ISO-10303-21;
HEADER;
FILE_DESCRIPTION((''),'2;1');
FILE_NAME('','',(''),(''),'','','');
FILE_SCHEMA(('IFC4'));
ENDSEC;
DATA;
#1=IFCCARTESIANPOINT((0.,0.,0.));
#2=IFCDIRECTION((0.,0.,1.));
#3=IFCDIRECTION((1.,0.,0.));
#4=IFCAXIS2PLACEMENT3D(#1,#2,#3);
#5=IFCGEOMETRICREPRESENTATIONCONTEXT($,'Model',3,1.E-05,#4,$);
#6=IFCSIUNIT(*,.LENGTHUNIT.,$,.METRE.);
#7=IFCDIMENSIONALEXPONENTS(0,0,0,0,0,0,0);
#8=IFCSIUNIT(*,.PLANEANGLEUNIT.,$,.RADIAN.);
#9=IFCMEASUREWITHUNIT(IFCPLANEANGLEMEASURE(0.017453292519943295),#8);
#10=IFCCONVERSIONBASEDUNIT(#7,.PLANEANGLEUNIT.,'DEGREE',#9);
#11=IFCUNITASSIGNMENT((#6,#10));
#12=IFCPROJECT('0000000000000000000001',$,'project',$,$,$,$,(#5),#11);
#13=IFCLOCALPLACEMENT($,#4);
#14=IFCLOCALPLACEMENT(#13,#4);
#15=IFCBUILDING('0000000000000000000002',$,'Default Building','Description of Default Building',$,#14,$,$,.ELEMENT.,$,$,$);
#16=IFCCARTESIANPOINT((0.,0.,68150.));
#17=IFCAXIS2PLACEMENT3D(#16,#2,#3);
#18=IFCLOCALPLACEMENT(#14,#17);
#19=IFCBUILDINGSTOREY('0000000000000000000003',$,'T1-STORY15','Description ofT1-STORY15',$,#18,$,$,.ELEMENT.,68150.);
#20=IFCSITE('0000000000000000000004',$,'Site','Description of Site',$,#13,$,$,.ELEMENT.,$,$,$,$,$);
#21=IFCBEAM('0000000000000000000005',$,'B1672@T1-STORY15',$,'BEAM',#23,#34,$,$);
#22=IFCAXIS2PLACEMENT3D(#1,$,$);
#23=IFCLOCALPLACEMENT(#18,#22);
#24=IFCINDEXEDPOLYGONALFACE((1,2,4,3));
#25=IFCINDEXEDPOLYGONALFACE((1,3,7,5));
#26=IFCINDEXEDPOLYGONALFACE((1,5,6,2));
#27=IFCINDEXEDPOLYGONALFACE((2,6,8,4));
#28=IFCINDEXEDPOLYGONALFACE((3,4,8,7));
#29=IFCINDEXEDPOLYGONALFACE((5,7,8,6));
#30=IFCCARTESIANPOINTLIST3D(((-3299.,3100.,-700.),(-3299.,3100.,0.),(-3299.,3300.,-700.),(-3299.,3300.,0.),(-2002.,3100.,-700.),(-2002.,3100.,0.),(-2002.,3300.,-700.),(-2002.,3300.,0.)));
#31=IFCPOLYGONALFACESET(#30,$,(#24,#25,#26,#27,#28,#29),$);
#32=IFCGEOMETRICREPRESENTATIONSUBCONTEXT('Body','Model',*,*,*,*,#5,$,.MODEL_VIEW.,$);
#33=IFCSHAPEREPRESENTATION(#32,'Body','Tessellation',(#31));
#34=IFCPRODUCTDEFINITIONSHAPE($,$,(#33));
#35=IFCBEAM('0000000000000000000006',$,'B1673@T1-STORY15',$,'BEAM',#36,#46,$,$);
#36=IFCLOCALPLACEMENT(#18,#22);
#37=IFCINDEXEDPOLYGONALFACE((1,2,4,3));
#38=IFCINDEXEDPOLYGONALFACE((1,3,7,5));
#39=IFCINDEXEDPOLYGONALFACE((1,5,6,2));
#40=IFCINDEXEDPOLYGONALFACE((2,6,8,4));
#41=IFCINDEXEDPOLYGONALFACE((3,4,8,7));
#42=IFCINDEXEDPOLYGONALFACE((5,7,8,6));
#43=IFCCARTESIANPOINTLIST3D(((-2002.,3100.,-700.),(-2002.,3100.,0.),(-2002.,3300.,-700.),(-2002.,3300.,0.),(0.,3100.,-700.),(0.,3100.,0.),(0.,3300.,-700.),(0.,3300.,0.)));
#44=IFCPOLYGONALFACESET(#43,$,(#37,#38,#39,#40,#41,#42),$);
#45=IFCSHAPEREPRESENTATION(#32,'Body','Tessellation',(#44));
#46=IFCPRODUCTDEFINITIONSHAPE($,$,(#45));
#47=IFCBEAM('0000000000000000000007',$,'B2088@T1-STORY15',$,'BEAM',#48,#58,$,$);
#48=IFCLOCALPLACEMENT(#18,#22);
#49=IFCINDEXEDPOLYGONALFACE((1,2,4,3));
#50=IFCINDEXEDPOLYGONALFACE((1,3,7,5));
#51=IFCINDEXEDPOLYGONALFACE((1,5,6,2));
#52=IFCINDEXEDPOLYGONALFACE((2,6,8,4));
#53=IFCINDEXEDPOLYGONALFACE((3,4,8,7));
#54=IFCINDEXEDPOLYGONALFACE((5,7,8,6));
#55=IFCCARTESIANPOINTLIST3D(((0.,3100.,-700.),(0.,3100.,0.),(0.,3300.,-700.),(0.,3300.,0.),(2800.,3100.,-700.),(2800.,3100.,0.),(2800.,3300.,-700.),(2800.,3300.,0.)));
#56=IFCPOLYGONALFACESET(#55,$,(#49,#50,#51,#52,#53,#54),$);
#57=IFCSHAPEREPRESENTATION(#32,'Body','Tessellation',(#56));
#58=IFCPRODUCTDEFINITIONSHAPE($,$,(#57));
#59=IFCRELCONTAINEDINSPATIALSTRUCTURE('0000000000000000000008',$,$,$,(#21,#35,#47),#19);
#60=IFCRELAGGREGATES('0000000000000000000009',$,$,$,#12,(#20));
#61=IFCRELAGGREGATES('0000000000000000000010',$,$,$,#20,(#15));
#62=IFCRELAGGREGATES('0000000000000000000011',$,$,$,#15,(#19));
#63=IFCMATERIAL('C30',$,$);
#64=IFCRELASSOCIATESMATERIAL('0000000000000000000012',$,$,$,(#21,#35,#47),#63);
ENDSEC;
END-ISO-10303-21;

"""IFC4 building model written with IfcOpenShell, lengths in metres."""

from ifc_helpers import new_model, entity, si_unit, converted_unit, frame, origin_with_axes, place, context, subcontext, project, spatial, rectangle, extrude, material, element, save


model = new_model("IFC4")

# Units and contexts
model_context = context("Model", 3, precision=1e-05, world=origin_with_axes())
body_context = subcontext(model_context, "Body", "Model", "MODEL_VIEW")
ifc_project = project(units=[si_unit("LENGTHUNIT", "METRE"), converted_unit("PLANEANGLEUNIT", "DEGREE", entity("IfcPlaneAngleMeasure", 0.017453292519943295), si_unit("PLANEANGLEUNIT", "RADIAN"), dimensions=[0, 0, 0, 0, 0, 0, 0])], contexts=[model_context])

# Site, building, storey
site_placement = place(None, origin_with_axes())
site = spatial("IfcSite", under=ifc_project, at=site_placement, Name="Site", Description="Description of Site", CompositionType="ELEMENT")
building_placement = place(site_placement, origin_with_axes())
building = spatial("IfcBuilding", under=site, at=building_placement, Name="Default Building", Description="Description of Default Building", CompositionType="ELEMENT")
storey_placement = place(building_placement, frame((0.0, 0.0, 68150.0), z_axis=(0.0, 0.0, 1.0), x_axis=(1.0, 0.0, 0.0)))
storey = spatial("IfcBuildingStorey", under=building, at=storey_placement, Name="T1-STORY15", Description="Description ofT1-STORY15", CompositionType="ELEMENT", Elevation=68150.0)

# Beams
ifc_material_1 = material(Name="C30")
beam_1_placement = place(storey_placement, frame((-3299.0, 3200.0, -350.0), z_axis=(1.0, 0.0, 0.0), x_axis=(0.0, 1.0, 0.0)))
element("IfcBeam", 1, at=beam_1_placement, inside=storey, material=ifc_material_1, Name="B1672@T1-STORY15", ObjectType="BEAM", context=body_context, shape_type="SweptSolid", body=[
    extrude(rectangle(XDim=200.0, YDim=700.0), origin_with_axes(), (0.0, 0.0, 1.0), 1297.0),
])
beam_2_placement = place(storey_placement, frame((-2002.0, 3200.0, -350.0), z_axis=(1.0, 0.0, 0.0), x_axis=(0.0, 1.0, 0.0)))
element("IfcBeam", 2, at=beam_2_placement, inside=storey, material=ifc_material_1, Name="B1673@T1-STORY15", ObjectType="BEAM", context=body_context, shape_type="SweptSolid", body=[
    extrude(rectangle(XDim=200.0, YDim=700.0), origin_with_axes(), (0.0, 0.0, 1.0), 2002.0),
])
beam_3_placement = place(storey_placement, frame((0.0, 3200.0, -350.0), z_axis=(1.0, 0.0, 0.0), x_axis=(0.0, 1.0, 0.0)))
element("IfcBeam", 3, at=beam_3_placement, inside=storey, material=ifc_material_1, Name="B2088@T1-STORY15", ObjectType="BEAM", context=body_context, shape_type="SweptSolid", body=[
    extrude(rectangle(XDim=200.0, YDim=700.0), origin_with_axes(), (0.0, 0.0, 1.0), 2800.0),
])

save(model, "model.ifc")
